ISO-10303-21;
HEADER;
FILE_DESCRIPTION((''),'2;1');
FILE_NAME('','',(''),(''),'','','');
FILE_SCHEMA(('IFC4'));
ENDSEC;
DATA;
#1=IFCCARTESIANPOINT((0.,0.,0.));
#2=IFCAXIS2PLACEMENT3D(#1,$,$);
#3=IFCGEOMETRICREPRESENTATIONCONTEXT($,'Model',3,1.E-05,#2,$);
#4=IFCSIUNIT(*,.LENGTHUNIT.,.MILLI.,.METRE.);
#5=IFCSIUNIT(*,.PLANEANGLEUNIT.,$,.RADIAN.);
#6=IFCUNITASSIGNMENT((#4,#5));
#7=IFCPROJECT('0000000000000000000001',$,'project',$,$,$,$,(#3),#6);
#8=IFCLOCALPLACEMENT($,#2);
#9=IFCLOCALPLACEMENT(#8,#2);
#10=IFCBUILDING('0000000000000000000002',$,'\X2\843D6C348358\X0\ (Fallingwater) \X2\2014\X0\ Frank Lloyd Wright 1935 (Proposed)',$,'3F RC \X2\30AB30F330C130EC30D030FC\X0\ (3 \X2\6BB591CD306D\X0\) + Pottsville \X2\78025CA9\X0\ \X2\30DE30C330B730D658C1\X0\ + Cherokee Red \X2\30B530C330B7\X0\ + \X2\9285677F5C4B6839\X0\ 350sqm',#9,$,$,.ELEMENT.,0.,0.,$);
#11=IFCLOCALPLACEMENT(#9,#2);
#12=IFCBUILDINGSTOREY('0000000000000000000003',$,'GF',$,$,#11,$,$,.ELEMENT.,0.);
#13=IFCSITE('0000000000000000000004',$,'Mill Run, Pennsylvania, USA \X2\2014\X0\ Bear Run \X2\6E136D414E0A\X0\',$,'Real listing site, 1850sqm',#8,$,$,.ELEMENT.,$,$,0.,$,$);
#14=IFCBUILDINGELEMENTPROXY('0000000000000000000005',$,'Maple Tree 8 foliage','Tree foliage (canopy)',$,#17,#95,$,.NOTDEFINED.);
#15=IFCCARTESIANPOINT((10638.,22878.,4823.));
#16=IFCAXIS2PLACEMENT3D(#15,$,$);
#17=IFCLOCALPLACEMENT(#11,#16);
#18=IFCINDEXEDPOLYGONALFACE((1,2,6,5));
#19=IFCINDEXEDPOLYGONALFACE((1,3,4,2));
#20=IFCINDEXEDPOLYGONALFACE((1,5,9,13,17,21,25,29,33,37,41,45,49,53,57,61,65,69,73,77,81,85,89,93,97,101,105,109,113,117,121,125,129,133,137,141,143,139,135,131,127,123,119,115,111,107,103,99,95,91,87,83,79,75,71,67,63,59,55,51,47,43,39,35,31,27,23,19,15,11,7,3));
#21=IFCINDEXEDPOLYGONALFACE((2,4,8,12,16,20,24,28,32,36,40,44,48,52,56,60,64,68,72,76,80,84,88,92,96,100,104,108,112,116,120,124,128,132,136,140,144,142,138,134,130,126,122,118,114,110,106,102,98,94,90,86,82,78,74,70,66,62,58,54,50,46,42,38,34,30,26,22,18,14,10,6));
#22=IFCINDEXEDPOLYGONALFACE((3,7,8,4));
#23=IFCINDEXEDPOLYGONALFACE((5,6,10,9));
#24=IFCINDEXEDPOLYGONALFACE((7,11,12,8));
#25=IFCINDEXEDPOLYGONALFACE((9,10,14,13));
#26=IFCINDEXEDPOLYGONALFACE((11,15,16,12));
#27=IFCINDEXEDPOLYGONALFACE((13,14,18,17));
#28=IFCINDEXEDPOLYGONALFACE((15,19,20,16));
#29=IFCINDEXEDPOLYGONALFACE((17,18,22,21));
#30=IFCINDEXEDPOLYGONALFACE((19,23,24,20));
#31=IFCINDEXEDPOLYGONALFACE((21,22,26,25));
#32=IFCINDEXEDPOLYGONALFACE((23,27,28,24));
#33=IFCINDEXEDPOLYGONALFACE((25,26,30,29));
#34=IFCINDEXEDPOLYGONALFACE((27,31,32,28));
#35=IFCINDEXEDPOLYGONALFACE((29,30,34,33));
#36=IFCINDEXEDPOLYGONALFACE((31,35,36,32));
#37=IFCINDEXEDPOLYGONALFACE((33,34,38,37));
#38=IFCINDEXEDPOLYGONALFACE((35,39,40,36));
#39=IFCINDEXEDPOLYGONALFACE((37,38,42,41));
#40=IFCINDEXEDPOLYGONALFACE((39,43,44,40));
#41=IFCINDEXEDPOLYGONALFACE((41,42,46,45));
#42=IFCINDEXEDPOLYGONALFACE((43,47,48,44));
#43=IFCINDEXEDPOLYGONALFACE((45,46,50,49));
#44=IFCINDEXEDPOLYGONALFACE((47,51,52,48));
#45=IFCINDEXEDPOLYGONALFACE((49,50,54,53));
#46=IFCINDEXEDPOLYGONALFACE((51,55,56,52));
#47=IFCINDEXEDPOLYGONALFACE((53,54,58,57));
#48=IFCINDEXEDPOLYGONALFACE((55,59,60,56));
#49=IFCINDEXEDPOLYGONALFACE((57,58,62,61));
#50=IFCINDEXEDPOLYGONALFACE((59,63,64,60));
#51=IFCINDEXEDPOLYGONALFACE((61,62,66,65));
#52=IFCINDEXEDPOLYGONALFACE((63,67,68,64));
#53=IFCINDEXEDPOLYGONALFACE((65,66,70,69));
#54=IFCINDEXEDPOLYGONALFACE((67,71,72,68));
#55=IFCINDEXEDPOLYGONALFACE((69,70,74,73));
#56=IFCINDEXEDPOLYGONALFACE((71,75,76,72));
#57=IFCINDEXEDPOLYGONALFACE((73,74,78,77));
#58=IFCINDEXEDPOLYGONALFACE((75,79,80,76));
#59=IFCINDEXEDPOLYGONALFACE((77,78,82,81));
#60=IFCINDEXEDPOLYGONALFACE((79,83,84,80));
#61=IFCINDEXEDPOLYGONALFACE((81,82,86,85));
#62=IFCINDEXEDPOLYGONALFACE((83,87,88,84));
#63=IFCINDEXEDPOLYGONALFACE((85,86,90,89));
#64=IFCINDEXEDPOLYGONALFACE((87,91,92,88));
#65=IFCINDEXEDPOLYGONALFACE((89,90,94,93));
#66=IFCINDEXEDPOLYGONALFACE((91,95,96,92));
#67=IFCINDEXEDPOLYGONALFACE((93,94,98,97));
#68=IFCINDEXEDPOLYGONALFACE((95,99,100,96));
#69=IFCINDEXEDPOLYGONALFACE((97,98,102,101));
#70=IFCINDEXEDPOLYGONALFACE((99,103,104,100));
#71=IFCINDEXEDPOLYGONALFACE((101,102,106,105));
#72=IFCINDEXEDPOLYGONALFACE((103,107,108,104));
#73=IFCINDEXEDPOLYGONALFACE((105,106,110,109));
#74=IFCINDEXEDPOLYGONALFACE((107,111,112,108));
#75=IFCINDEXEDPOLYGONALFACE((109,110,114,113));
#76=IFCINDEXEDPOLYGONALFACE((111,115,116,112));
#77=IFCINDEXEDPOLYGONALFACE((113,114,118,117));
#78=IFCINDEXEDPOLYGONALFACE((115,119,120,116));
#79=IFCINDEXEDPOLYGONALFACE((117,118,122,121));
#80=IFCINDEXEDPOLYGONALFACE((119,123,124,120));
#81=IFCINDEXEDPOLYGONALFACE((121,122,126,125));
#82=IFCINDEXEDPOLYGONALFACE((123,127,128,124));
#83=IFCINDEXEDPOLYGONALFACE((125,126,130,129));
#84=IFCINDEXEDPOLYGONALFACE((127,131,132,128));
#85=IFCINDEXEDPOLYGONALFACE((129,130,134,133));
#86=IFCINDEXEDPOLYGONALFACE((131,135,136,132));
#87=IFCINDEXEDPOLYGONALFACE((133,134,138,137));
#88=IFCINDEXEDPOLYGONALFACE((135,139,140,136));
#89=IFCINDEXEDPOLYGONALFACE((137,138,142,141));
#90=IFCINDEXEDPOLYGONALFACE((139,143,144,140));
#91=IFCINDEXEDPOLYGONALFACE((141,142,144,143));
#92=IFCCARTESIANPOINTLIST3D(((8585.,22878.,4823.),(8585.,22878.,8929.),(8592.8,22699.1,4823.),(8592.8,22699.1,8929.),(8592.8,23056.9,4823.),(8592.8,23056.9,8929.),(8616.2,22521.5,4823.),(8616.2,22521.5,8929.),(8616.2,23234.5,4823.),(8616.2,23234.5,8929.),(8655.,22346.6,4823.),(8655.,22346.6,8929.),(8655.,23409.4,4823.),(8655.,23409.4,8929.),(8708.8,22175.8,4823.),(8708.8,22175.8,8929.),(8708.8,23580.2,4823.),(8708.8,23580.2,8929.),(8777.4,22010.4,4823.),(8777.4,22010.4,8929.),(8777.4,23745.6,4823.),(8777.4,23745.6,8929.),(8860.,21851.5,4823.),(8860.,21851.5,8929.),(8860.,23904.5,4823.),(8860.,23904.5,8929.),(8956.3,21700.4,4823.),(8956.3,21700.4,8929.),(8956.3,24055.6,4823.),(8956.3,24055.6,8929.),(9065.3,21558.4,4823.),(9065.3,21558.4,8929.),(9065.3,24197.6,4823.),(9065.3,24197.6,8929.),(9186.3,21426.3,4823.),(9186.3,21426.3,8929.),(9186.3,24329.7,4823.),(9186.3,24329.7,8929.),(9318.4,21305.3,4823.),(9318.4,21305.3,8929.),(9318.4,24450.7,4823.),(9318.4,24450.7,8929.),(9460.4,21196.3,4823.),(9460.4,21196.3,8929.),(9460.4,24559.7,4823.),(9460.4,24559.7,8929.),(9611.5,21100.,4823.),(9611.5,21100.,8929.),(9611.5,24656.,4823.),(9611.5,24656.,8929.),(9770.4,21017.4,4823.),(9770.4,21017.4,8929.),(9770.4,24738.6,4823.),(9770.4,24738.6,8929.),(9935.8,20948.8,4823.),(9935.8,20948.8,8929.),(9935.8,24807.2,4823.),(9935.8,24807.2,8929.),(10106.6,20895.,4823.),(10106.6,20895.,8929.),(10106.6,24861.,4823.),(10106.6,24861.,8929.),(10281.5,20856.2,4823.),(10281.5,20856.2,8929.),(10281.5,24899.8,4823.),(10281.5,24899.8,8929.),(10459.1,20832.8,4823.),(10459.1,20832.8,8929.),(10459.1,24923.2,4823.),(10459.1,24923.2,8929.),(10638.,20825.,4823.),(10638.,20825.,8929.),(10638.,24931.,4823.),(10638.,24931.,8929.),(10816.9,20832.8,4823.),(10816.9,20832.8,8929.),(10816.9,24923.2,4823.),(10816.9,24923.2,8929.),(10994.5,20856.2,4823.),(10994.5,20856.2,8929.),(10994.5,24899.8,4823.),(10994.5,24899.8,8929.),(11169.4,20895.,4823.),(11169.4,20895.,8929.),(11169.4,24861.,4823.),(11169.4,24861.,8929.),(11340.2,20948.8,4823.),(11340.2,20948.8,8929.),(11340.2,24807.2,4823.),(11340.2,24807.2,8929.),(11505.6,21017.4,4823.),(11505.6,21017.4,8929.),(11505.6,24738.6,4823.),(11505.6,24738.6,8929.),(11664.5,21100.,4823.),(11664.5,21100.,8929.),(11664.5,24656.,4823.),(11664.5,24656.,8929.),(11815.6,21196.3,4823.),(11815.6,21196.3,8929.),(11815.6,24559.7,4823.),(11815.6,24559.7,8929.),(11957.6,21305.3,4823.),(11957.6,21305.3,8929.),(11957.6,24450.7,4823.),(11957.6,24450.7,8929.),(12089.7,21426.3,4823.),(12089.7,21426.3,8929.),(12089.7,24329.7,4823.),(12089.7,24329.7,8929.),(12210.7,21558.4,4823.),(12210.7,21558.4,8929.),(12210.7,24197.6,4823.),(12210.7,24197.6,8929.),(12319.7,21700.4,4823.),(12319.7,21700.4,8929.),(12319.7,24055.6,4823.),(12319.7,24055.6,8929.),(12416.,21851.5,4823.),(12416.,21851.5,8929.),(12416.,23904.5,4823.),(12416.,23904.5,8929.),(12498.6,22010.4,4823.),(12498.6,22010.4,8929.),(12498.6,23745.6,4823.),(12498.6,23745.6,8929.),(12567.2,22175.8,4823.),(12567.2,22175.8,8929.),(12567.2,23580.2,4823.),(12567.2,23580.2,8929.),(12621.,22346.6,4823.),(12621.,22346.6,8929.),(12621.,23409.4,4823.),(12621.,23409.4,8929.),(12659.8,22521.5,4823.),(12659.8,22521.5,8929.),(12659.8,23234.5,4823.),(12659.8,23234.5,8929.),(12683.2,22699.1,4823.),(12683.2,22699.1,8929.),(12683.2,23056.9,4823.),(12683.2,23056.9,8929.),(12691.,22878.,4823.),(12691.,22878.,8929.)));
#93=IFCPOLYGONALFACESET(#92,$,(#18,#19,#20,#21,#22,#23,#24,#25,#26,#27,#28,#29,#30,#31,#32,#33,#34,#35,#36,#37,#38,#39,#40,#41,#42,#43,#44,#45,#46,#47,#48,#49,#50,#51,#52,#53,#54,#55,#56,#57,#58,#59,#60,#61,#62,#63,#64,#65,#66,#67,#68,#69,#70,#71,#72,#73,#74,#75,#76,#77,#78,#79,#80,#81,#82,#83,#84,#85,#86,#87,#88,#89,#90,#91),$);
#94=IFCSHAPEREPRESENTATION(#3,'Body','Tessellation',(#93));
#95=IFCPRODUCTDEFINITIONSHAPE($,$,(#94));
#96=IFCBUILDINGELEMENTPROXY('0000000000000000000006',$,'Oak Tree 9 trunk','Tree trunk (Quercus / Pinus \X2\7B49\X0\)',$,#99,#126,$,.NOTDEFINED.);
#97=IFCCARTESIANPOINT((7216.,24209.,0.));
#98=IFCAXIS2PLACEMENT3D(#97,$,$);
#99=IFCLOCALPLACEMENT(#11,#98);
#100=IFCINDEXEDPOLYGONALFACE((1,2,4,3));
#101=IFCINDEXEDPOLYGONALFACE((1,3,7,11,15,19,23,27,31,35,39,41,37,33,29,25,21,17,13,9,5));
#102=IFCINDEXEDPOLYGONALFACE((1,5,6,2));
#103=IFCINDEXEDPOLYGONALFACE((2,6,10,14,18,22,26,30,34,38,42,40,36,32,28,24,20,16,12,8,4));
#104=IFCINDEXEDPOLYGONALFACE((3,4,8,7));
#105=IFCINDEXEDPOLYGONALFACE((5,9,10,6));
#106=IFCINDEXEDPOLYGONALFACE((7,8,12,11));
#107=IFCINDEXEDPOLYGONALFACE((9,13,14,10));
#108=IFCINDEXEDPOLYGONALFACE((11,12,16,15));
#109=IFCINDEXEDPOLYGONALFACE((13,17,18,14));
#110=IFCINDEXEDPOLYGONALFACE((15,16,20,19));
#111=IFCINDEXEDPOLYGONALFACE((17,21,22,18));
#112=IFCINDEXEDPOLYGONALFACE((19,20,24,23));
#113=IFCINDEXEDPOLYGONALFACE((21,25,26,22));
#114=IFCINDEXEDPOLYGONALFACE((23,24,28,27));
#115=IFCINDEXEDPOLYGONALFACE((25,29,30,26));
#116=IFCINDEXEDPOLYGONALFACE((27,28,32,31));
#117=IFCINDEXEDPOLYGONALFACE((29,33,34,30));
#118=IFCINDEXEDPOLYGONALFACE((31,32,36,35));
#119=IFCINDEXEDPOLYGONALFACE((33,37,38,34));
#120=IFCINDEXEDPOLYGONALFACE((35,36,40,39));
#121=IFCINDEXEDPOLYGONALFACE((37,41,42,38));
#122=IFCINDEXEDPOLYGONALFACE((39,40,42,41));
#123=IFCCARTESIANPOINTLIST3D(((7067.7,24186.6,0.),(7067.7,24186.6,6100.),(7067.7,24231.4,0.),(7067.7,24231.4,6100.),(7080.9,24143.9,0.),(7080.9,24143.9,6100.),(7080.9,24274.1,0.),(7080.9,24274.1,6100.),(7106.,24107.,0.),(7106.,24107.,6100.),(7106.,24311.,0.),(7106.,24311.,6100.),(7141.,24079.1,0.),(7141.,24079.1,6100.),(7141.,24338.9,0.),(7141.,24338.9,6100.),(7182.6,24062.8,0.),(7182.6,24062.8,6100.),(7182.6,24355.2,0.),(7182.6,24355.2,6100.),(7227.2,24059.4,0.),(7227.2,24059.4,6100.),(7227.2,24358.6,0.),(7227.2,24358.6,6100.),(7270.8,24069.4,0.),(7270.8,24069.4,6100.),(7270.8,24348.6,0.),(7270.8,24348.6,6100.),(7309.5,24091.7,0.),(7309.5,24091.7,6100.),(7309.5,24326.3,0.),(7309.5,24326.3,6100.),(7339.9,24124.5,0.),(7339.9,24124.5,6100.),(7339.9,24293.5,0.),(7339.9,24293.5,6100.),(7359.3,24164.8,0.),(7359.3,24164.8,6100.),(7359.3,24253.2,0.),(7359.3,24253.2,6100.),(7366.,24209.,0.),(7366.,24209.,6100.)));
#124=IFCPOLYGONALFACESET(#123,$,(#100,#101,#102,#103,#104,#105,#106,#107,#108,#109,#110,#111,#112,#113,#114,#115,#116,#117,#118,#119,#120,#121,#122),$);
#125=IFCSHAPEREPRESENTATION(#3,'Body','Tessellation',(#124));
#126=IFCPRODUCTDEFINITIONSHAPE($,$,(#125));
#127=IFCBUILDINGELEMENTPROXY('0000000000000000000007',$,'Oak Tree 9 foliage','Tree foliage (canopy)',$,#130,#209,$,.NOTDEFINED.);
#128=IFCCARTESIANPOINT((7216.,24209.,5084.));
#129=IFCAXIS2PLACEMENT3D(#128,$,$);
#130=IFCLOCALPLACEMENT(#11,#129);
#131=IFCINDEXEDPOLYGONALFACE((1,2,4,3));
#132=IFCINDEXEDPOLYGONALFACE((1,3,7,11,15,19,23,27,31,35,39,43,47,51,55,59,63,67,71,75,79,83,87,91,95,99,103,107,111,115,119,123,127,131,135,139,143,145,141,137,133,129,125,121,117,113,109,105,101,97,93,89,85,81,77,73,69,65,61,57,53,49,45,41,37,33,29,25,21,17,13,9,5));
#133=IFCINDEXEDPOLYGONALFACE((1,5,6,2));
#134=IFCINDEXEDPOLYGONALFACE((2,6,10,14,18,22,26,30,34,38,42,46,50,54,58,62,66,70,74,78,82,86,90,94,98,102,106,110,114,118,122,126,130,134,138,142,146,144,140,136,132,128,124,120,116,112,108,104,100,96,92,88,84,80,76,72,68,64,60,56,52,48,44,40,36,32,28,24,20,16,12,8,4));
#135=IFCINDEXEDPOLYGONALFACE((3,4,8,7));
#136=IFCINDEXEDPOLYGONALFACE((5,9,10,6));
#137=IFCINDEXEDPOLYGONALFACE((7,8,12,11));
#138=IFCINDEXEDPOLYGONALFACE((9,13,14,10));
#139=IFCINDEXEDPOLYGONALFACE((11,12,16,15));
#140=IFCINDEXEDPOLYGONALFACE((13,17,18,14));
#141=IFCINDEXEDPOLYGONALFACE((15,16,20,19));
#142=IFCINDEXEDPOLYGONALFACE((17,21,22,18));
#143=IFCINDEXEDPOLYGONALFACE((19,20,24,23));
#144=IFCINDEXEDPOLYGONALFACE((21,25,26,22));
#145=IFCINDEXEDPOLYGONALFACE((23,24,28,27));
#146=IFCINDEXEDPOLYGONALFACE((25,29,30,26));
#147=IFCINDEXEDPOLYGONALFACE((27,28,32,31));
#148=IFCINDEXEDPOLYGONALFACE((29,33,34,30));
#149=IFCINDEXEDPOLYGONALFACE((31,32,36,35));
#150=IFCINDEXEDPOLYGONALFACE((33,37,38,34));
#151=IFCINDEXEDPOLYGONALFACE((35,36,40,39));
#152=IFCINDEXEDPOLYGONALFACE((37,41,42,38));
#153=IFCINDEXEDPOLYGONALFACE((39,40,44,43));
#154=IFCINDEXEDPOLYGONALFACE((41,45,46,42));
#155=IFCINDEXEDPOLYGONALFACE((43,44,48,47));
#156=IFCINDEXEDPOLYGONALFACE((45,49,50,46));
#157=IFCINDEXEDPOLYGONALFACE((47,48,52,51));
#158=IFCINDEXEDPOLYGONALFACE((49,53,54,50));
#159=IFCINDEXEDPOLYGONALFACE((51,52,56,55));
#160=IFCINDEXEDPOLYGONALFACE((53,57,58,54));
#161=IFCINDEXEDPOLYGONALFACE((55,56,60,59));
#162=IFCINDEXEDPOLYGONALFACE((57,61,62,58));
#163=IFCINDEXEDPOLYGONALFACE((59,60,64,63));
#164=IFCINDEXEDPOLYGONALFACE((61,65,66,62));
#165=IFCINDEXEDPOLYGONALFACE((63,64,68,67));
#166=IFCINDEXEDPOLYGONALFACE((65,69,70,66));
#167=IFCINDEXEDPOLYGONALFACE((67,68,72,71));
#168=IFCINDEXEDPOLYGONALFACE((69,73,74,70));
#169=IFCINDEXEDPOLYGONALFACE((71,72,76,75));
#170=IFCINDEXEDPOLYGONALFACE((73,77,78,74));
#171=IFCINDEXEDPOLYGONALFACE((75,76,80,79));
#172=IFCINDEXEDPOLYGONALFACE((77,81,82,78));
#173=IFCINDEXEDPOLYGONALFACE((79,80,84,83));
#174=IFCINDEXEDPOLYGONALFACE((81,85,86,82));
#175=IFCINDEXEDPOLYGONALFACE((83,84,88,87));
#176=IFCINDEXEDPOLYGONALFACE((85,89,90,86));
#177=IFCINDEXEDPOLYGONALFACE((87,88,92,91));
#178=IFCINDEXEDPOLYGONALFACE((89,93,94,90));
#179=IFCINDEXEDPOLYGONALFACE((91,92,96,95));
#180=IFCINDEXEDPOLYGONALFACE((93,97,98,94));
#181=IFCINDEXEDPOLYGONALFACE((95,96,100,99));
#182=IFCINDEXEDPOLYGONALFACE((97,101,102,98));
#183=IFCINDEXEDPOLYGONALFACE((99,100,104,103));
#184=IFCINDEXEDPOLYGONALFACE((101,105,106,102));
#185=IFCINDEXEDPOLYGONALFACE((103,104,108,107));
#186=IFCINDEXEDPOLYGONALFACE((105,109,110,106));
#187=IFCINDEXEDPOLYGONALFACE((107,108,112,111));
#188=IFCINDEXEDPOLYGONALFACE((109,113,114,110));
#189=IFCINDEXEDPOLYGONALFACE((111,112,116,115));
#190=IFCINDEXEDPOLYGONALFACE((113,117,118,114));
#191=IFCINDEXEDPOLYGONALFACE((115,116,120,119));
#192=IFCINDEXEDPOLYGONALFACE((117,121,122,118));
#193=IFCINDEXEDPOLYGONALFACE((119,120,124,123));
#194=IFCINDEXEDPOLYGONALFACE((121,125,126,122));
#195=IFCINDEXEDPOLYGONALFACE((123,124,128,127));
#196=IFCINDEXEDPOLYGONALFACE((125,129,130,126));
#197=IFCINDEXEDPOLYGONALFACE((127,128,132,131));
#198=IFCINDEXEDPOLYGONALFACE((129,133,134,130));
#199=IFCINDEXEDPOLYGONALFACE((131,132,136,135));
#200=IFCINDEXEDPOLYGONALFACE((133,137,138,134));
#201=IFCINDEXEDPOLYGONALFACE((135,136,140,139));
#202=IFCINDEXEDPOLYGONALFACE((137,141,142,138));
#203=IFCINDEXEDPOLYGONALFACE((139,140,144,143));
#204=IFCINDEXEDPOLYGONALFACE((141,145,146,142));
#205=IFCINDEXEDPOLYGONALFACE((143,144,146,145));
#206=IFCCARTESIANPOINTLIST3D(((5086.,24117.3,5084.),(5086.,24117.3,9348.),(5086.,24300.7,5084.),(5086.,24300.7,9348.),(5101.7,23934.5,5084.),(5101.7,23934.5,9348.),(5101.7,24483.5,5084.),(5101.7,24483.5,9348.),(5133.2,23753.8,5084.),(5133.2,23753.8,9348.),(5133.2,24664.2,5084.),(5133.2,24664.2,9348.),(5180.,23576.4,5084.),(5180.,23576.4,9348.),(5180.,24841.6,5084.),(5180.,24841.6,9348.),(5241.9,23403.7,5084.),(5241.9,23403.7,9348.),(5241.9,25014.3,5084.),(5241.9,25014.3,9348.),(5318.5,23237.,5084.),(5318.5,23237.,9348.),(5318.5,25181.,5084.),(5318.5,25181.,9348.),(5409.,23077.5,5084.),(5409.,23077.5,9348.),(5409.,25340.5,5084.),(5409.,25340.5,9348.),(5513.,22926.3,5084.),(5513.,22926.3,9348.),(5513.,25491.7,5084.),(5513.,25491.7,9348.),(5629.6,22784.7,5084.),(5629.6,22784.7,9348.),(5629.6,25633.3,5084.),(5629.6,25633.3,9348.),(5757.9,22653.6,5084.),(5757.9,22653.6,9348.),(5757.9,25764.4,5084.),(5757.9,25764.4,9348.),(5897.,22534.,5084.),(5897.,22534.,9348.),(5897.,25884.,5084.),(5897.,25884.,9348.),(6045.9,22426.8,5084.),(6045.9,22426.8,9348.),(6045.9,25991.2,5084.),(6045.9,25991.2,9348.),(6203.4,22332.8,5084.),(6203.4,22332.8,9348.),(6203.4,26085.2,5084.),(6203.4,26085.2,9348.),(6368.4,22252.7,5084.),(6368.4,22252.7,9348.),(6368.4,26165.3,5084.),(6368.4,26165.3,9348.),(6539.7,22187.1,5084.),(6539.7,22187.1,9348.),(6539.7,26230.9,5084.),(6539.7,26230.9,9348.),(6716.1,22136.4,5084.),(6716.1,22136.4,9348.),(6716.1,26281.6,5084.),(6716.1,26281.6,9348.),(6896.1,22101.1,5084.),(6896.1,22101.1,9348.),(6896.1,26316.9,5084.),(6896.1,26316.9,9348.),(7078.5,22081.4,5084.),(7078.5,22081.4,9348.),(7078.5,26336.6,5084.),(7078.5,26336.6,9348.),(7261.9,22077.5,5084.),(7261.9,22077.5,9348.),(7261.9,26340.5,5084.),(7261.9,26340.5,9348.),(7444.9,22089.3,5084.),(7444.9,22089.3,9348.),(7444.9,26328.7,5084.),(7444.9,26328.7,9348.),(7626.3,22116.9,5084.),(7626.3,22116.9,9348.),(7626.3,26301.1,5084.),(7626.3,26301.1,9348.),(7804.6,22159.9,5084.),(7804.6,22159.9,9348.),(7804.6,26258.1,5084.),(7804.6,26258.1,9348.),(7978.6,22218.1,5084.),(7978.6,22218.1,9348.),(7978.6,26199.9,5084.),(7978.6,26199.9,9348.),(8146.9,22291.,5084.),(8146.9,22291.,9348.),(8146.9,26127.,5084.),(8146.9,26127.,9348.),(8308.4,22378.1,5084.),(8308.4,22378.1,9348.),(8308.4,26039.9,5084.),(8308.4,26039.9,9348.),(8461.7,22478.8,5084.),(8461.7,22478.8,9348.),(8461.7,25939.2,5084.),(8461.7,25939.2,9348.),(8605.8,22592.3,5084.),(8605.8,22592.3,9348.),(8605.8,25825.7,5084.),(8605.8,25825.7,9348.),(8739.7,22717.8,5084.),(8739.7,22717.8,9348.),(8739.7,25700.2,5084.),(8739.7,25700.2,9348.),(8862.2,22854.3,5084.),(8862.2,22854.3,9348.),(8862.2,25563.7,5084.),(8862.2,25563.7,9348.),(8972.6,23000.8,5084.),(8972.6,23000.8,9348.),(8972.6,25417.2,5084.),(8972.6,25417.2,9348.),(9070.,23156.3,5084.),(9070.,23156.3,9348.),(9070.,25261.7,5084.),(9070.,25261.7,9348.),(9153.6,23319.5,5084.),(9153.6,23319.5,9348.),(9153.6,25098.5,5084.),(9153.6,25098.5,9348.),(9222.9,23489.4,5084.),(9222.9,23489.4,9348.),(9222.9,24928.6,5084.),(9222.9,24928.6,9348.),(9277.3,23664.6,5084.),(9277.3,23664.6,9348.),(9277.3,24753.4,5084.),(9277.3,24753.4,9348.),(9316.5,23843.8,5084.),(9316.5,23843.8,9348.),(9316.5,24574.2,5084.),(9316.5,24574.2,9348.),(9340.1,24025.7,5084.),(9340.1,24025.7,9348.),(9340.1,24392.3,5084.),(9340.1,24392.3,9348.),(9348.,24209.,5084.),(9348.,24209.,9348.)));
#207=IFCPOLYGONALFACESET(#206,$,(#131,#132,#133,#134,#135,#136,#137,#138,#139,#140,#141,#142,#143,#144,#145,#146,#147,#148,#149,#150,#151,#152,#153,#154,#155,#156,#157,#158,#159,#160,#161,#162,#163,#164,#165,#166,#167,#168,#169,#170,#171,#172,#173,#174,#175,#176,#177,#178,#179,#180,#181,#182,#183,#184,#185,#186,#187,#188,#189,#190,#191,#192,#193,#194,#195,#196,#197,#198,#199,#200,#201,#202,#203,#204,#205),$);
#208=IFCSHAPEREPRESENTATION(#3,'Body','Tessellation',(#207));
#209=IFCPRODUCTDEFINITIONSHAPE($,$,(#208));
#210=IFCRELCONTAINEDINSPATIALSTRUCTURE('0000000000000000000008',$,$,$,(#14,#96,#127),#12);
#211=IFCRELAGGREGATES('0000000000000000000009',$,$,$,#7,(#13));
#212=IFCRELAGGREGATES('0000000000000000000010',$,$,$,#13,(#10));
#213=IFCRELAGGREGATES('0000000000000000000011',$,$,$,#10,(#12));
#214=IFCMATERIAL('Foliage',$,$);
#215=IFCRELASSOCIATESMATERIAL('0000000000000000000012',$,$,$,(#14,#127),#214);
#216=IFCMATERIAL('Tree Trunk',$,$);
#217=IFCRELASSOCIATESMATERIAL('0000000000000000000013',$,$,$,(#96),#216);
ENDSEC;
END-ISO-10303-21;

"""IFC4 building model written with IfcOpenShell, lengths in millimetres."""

from ifc_helpers import new_model, si_unit, frame, origin, origin_2d, place, context, project, spatial, circle, extrude, material, element, save


model = new_model("IFC4")

# Units and contexts
model_context = context("Model", 3, precision=1e-05, world=origin())
ifc_project = project(units=[si_unit("LENGTHUNIT", "METRE", prefix="MILLI"), si_unit("PLANEANGLEUNIT", "RADIAN")], contexts=[model_context])

# Site, building, storey
site_placement = place(None, origin())
site = spatial("IfcSite", under=ifc_project, at=site_placement, Name="Mill Run, Pennsylvania, USA — Bear Run 渓流上", ObjectType="Real listing site, 1850sqm", CompositionType="ELEMENT", RefElevation=0.0)
building_placement = place(site_placement, origin())
building = spatial("IfcBuilding", under=site, at=building_placement, Name="落水荘 (Fallingwater) — Frank Lloyd Wright 1935 (Proposed)", ObjectType="3F RC カンチレバー (3 段重ね) + Pottsville 砂岩 マッシブ壁 + Cherokee Red サッシ + 銅板屋根 350sqm", CompositionType="ELEMENT", ElevationOfRefHeight=0.0, ElevationOfTerrain=0.0)
storey_placement = place(building_placement, origin())
storey = spatial("IfcBuildingStorey", under=building, at=storey_placement, Name="GF", CompositionType="ELEMENT", Elevation=0.0)

# Building element proxies
ifc_material_1 = material(Name="Tree Trunk")
ifc_material_2 = material(Name="Foliage")
proxy_1_placement = place(storey_placement, frame((10638.0, 22878.0, 4823.0)))
element("IfcBuildingElementProxy", 1, at=proxy_1_placement, inside=storey, material=ifc_material_2, Name="Maple Tree 8 foliage", Description="Tree foliage (canopy)", PredefinedType="NOTDEFINED", context=model_context, shape_type="SweptSolid", body=[
    extrude(circle(Radius=2053.0, at=origin_2d()), frame((10638.0, 22878.0, 4823.0)), (0.0, 0.0, 1.0), 4106.0),
])
proxy_2_placement = place(storey_placement, frame((7216.0, 24209.0, 0.0)))
element("IfcBuildingElementProxy", 2, at=proxy_2_placement, inside=storey, material=ifc_material_1, Name="Oak Tree 9 trunk", Description="Tree trunk (Quercus / Pinus 等)", PredefinedType="NOTDEFINED", context=model_context, shape_type="SweptSolid", body=[
    extrude(circle(Radius=150.0, at=origin_2d()), frame((7216.0, 24209.0, 0.0)), (0.0, 0.0, 1.0), 6100.0),
])
proxy_3_placement = place(storey_placement, frame((7216.0, 24209.0, 5084.0)))
element("IfcBuildingElementProxy", 3, at=proxy_3_placement, inside=storey, material=ifc_material_2, Name="Oak Tree 9 foliage", Description="Tree foliage (canopy)", PredefinedType="NOTDEFINED", context=model_context, shape_type="SweptSolid", body=[
    extrude(circle(Radius=2132.0, at=origin_2d()), frame((7216.0, 24209.0, 5084.0)), (0.0, 0.0, 1.0), 4264.0),
])

save(model, "model.ifc")
